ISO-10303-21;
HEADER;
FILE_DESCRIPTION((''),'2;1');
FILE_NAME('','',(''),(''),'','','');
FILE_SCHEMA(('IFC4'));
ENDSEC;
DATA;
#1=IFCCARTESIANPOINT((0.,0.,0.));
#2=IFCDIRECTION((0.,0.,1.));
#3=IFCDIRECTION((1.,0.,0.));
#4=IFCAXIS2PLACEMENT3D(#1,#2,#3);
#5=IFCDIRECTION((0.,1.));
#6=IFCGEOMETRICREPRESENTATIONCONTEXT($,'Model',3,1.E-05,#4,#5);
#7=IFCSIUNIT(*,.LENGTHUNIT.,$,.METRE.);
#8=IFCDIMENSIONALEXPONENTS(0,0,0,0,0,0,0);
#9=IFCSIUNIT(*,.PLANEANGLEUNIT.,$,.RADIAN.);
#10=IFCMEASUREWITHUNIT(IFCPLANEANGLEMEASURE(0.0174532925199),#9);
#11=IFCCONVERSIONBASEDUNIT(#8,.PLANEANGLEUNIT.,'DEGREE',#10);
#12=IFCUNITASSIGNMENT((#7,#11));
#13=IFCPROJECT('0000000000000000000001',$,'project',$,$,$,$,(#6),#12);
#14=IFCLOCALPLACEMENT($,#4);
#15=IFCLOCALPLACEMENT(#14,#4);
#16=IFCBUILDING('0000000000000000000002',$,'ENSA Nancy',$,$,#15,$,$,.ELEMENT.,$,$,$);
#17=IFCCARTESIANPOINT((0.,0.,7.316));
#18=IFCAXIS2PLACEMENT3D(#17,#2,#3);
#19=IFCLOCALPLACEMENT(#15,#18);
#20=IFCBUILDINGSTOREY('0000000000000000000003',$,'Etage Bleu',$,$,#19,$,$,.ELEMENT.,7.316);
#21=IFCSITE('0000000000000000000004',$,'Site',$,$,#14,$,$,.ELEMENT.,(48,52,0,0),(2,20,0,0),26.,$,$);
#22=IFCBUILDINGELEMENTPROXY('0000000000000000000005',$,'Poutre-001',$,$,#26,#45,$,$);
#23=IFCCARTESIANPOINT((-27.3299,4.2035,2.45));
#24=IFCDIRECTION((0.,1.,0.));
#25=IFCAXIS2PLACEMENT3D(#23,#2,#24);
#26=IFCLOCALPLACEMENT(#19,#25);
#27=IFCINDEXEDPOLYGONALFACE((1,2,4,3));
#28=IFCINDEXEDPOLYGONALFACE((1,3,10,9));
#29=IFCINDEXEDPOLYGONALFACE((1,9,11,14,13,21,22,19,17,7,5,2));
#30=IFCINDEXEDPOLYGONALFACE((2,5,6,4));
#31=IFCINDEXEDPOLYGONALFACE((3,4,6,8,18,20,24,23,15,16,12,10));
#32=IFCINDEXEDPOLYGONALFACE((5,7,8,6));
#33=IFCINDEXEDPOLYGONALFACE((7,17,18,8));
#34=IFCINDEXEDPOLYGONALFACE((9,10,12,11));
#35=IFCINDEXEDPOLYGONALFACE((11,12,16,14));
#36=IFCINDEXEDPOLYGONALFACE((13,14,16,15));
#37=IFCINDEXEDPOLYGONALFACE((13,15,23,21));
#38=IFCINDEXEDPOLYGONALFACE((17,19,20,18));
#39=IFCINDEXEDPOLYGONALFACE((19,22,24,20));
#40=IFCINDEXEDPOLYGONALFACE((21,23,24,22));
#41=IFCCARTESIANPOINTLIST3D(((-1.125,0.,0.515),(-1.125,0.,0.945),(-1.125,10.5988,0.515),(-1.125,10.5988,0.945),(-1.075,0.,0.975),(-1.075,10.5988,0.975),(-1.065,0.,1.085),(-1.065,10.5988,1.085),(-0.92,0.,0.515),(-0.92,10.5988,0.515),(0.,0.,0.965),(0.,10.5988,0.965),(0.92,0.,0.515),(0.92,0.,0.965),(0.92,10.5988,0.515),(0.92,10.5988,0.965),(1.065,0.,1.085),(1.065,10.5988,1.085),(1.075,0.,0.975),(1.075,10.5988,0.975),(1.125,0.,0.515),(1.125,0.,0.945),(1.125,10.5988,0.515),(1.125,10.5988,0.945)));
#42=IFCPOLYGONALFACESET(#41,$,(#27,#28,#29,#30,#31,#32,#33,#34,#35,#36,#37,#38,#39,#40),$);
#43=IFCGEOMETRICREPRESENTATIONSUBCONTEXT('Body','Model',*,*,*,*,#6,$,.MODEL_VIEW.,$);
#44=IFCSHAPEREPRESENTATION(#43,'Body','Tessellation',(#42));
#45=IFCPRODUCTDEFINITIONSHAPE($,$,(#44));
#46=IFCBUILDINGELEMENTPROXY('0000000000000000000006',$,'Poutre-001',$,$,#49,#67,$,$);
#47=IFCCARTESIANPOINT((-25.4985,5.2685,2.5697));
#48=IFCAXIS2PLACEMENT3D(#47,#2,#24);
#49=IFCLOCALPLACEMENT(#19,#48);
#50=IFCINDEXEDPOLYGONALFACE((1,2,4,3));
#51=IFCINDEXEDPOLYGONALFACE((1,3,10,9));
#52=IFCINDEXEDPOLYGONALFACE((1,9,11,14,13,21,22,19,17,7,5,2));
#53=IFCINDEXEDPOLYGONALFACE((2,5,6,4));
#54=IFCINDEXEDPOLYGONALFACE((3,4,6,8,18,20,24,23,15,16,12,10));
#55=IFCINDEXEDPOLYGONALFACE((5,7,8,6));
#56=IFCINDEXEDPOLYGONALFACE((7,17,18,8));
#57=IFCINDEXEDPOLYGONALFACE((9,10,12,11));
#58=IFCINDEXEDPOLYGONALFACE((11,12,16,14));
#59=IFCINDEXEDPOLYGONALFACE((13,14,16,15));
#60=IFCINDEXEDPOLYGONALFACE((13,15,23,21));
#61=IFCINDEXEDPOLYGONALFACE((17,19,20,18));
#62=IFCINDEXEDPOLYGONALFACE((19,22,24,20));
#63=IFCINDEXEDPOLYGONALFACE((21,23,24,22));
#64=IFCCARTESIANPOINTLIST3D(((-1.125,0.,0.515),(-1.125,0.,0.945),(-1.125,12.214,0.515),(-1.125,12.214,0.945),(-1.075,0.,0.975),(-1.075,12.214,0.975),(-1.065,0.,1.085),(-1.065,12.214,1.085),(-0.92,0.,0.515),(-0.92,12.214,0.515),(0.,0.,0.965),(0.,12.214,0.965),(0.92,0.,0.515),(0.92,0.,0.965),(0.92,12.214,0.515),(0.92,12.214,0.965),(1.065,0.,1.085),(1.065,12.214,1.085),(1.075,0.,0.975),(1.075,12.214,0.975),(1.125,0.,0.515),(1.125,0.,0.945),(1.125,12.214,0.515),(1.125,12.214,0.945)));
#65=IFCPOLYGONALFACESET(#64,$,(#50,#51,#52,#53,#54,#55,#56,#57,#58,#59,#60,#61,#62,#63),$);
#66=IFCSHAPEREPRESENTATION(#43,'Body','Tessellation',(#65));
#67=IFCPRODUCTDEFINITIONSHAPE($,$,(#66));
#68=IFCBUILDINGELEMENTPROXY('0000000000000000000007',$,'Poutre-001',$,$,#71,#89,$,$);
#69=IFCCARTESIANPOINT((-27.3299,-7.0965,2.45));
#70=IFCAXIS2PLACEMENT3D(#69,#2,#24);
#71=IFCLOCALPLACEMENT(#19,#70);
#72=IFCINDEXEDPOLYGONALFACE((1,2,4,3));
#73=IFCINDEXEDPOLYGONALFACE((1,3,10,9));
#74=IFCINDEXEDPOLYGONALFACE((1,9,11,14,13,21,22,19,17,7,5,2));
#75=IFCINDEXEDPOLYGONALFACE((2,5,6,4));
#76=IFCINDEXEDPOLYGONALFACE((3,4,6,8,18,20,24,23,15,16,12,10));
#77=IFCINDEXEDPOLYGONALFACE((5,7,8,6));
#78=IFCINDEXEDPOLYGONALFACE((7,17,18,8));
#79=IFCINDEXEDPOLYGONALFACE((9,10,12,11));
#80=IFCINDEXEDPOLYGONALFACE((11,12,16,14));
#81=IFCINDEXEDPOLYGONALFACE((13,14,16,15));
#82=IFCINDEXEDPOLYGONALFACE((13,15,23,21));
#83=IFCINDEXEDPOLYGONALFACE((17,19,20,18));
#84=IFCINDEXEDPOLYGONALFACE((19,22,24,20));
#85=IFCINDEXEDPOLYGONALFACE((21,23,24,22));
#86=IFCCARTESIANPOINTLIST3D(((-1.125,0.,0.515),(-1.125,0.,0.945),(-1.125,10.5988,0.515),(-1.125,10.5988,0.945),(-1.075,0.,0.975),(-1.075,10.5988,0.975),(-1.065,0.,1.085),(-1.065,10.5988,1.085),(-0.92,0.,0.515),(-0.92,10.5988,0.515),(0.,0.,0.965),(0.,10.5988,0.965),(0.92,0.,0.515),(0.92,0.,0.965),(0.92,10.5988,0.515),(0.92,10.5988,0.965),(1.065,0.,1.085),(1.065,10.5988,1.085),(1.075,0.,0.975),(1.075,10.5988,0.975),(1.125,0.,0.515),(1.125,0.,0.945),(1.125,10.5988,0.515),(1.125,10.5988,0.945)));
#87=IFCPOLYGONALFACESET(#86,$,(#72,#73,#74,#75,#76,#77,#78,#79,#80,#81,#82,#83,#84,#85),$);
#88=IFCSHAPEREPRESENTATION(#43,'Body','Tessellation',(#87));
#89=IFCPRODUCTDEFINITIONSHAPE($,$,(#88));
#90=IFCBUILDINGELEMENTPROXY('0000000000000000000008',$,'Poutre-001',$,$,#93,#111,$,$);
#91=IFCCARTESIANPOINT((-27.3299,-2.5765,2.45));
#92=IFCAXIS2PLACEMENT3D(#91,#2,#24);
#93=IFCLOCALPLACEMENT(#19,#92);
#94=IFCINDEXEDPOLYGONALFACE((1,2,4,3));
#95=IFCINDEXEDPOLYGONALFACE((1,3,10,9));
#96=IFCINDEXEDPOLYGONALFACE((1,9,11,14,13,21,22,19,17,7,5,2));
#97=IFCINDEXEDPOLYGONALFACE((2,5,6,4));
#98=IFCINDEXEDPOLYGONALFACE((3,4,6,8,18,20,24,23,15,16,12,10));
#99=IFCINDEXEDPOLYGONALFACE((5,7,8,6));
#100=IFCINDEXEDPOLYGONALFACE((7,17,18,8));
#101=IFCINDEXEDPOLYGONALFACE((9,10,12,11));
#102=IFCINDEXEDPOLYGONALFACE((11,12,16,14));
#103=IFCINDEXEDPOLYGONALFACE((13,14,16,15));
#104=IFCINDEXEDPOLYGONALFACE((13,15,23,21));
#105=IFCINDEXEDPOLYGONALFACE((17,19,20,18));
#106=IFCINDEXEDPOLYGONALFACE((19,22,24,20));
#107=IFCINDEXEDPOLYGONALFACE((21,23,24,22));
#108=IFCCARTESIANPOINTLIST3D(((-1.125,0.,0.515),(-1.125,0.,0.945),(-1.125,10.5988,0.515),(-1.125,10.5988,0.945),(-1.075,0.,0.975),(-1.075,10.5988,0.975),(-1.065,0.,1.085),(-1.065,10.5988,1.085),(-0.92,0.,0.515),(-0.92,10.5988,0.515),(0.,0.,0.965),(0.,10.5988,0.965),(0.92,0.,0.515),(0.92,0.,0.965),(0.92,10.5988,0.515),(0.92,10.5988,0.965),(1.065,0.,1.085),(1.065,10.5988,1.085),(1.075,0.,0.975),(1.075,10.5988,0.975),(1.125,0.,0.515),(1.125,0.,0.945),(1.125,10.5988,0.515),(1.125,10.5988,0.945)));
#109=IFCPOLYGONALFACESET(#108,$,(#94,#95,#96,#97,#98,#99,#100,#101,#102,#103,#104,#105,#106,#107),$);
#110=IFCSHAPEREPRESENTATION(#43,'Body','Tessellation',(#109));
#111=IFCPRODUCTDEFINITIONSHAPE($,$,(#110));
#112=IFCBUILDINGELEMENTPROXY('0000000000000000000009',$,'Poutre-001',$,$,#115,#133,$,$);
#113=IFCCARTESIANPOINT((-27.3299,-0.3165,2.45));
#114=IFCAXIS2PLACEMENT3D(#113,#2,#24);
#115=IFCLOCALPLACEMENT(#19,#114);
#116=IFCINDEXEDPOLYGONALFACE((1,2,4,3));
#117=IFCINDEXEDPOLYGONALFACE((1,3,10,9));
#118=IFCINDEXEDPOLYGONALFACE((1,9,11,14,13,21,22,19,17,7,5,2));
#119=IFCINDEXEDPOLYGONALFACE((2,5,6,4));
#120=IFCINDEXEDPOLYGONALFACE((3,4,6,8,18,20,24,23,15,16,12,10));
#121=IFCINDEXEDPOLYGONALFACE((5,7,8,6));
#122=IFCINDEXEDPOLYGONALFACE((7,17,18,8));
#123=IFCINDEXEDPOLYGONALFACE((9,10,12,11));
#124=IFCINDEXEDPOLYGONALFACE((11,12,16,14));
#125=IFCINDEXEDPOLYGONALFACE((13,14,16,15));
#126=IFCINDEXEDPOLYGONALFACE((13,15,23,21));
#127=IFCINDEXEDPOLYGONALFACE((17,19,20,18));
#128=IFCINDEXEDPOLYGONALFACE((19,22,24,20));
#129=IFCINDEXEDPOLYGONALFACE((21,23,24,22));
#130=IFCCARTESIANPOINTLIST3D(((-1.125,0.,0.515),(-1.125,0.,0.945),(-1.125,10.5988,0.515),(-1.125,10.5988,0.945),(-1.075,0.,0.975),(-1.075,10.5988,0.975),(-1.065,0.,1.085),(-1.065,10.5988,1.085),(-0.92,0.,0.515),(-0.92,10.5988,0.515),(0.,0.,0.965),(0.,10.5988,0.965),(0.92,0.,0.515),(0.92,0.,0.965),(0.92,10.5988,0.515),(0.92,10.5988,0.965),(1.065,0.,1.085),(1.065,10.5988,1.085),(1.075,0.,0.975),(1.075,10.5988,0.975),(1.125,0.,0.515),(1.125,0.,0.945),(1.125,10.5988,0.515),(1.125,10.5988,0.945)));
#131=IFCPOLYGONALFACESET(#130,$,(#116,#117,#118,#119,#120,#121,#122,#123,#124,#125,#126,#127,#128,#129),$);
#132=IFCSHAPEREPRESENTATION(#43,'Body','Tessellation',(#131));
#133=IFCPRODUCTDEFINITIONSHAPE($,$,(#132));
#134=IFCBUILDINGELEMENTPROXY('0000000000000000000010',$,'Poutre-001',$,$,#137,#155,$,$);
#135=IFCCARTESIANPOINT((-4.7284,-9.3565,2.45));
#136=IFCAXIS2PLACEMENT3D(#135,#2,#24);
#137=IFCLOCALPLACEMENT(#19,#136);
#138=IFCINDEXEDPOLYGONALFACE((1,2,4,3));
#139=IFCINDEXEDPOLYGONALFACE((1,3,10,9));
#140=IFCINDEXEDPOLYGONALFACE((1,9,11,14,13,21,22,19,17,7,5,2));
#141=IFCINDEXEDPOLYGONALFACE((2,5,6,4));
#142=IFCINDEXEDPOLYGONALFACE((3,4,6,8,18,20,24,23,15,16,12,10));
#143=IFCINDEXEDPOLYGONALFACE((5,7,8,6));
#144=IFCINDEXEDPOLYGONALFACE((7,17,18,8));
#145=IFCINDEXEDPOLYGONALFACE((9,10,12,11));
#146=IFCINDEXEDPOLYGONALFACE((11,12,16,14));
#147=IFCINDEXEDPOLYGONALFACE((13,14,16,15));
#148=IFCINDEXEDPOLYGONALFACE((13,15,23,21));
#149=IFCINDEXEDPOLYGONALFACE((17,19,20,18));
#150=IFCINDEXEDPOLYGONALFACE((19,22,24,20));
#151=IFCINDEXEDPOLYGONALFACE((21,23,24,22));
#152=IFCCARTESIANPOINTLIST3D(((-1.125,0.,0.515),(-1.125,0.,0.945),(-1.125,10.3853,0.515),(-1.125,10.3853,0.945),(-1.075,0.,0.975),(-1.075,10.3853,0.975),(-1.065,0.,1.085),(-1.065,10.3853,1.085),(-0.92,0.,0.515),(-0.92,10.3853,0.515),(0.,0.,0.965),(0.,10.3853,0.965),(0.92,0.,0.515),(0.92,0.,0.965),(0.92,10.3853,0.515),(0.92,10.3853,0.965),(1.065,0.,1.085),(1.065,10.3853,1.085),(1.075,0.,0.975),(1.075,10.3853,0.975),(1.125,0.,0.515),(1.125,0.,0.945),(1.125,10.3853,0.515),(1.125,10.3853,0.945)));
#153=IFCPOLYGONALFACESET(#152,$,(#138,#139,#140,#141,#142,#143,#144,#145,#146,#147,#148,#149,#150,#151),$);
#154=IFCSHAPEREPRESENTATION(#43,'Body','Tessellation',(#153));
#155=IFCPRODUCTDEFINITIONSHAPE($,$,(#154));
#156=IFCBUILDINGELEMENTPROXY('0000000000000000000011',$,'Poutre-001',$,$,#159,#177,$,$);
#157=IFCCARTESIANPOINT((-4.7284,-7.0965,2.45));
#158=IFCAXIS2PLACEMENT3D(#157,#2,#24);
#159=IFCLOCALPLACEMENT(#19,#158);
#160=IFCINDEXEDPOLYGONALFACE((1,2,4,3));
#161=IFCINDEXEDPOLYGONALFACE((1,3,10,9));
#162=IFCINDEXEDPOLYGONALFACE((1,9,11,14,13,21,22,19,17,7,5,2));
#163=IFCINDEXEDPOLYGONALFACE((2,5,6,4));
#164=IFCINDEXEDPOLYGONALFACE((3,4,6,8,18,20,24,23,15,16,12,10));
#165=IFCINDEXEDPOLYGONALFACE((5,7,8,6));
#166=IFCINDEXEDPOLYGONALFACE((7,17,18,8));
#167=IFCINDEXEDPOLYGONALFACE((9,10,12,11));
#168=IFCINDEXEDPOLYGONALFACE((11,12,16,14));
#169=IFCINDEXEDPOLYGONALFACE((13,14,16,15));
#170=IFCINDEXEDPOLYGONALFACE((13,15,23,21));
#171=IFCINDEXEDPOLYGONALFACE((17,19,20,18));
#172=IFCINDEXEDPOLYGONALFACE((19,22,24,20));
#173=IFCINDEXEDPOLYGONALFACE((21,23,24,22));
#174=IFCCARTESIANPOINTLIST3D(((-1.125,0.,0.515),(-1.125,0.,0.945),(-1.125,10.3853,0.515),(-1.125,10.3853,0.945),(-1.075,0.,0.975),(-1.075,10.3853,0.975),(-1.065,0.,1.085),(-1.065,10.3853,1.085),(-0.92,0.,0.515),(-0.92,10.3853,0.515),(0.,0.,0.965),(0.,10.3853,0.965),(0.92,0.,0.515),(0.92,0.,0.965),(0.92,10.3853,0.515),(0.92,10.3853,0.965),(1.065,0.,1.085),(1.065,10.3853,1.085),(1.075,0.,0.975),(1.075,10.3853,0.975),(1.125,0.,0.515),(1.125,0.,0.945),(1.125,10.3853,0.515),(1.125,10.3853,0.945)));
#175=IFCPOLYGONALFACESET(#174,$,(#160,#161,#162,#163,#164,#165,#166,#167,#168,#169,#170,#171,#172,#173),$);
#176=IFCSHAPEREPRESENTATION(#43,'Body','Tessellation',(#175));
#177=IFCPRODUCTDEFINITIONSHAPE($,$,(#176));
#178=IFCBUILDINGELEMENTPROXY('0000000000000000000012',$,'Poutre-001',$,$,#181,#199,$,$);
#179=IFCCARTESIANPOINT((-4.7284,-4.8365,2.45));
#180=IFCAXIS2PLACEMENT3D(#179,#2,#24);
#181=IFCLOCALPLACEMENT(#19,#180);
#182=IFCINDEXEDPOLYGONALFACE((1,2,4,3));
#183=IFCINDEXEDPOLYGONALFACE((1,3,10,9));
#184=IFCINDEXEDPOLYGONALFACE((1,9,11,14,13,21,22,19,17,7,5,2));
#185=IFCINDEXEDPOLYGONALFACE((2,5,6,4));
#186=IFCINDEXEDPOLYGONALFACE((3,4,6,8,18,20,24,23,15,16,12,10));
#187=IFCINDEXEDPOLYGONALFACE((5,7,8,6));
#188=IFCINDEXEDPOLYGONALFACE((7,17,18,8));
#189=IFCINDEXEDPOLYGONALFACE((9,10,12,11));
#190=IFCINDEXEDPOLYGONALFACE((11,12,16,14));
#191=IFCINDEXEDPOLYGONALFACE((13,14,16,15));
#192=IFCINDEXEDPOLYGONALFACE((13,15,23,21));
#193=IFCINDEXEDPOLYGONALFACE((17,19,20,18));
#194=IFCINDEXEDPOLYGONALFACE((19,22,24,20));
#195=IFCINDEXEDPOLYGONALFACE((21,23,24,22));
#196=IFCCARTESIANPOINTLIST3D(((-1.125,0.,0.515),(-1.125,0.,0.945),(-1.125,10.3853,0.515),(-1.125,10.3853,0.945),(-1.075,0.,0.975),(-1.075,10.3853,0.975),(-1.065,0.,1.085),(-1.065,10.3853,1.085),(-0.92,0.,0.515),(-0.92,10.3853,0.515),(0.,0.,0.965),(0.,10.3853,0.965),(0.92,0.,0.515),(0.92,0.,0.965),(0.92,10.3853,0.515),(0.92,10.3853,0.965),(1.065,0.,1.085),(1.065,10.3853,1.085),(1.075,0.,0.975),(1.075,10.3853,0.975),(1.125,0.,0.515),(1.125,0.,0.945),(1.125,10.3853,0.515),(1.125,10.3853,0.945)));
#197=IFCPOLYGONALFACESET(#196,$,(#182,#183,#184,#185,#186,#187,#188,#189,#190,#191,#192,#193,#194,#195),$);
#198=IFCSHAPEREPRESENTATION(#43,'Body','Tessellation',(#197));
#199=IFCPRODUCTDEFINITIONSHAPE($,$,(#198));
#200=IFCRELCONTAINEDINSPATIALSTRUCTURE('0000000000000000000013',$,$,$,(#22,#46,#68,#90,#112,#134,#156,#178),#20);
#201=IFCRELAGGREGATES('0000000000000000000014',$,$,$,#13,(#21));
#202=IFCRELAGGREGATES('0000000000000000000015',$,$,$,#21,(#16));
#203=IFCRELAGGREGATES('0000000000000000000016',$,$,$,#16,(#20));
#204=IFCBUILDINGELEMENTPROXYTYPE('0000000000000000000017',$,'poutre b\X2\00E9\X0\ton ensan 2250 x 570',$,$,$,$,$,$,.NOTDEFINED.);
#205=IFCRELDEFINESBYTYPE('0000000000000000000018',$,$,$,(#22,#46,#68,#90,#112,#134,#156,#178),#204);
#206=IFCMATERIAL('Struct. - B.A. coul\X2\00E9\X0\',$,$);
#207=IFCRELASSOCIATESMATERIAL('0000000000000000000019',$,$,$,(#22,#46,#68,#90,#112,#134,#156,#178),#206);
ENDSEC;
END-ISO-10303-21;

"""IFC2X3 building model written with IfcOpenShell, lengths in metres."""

from ifc_helpers import new_model, entity, si_unit, converted_unit, direction, frame, origin_with_axes, place, context, subcontext, project, spatial, polyline, outline, extrude, material, type_object, element, save


model = new_model("IFC2X3")

# Units and contexts
model_context = context("Model", 3, precision=1e-05, world=origin_with_axes(), true_north=direction((0.0, 1.0)))
body_context = subcontext(model_context, "Body", "Model", "MODEL_VIEW")
ifc_project = project(units=[si_unit("LENGTHUNIT", "METRE"), converted_unit("PLANEANGLEUNIT", "DEGREE", entity("IfcPlaneAngleMeasure", 0.0174532925199), si_unit("PLANEANGLEUNIT", "RADIAN"), dimensions=[0, 0, 0, 0, 0, 0, 0])], contexts=[model_context])

# Site, building, storey
site_placement = place(None, origin_with_axes())
site = spatial("IfcSite", under=ifc_project, at=site_placement, Name="Site", CompositionType="ELEMENT", RefLatitude=(48, 52, 0, 0), RefLongitude=(2, 20, 0, 0), RefElevation=26.0)
building_placement = place(site_placement, origin_with_axes())
building = spatial("IfcBuilding", under=site, at=building_placement, Name="ENSA Nancy", CompositionType="ELEMENT")
storey_placement = place(building_placement, frame((0.0, 0.0, 7.316), z_axis=(0.0, 0.0, 1.0), x_axis=(1.0, 0.0, 0.0)))
storey = spatial("IfcBuildingStorey", under=building, at=storey_placement, Name="Etage Bleu", CompositionType="ELEMENT", Elevation=7.316)

# Building element proxies
ifc_material_1 = material(Name="Struct. - B.A. coulé")
building_element_proxy_type_1 = type_object("IfcBuildingElementProxyType", Name="poutre béton ensan 2250 x 570", PredefinedType="NOTDEFINED")
proxy_1_placement = place(storey_placement, frame((-27.3299, 4.2035, 2.45), z_axis=(0.0, 0.0, 1.0), x_axis=(0.0, 1.0, 0.0)))
element("IfcBuildingElementProxy", 1, at=proxy_1_placement, inside=storey, type_object=building_element_proxy_type_1, material=ifc_material_1, Name="Poutre-001", context=body_context, shape_type="SweptSolid", body=[
    extrude(outline(polyline([(-1.065, 1.085), (-1.075, 0.975), (-1.125, 0.945), (-1.125, 0.515), (-0.92, 0.515), (0.0, 0.965), (0.92, 0.965), (0.92, 0.515), (1.125, 0.515), (1.125, 0.945), (1.075, 0.975), (1.065, 1.085), (-1.065, 1.085)])), frame((0.0, 10.5988, 0.0), z_axis=(0.0, -1.0, 0.0), x_axis=(1.0, 0.0, 0.0)), (0.0, 0.0, 1.0), 10.5988),
])
proxy_2_placement = place(storey_placement, frame((-25.4985, 5.2685, 2.5697), z_axis=(0.0, 0.0, 1.0), x_axis=(0.0, 1.0, 0.0)))
element("IfcBuildingElementProxy", 2, at=proxy_2_placement, inside=storey, type_object=building_element_proxy_type_1, material=ifc_material_1, Name="Poutre-001", context=body_context, shape_type="SweptSolid", body=[
    extrude(outline(polyline([(-1.065, 1.085), (-1.075, 0.975), (-1.125, 0.945), (-1.125, 0.515), (-0.92, 0.515), (0.0, 0.965), (0.92, 0.965), (0.92, 0.515), (1.125, 0.515), (1.125, 0.945), (1.075, 0.975), (1.065, 1.085), (-1.065, 1.085)])), frame((0.0, 12.214, 0.0), z_axis=(0.0, -1.0, 0.0), x_axis=(1.0, 0.0, 0.0)), (0.0, 0.0, 1.0), 12.214),
])
for number, where, z_axis, x_axis, name in (
    (3, (-27.3299, -7.0965, 2.45), (0.0, 0.0, 1.0), (0.0, 1.0, 0.0), "Poutre-001"),
    (4, (-27.3299, -2.5765, 2.45), (0.0, 0.0, 1.0), (0.0, 1.0, 0.0), "Poutre-001"),
    (5, (-27.3299, -0.3165, 2.45), (0.0, 0.0, 1.0), (0.0, 1.0, 0.0), "Poutre-001"),
):
    element("IfcBuildingElementProxy", number, at=place(storey_placement, frame(where, z_axis=z_axis, x_axis=x_axis)), inside=storey, type_object=building_element_proxy_type_1, material=ifc_material_1, Name=name, context=body_context, shape_type="SweptSolid", body=[
        extrude(outline(polyline([(-1.065, 1.085), (-1.075, 0.975), (-1.125, 0.945), (-1.125, 0.515), (-0.92, 0.515), (0.0, 0.965), (0.92, 0.965), (0.92, 0.515), (1.125, 0.515), (1.125, 0.945), (1.075, 0.975), (1.065, 1.085), (-1.065, 1.085)])), frame((0.0, 10.5988, 0.0), z_axis=(0.0, -1.0, 0.0), x_axis=(1.0, 0.0, 0.0)), (0.0, 0.0, 1.0), 10.5988),
    ])
for number, where, z_axis, x_axis, name in (
    (6, (-4.7284, -9.3565, 2.45), (0.0, 0.0, 1.0), (0.0, 1.0, 0.0), "Poutre-001"),
    (7, (-4.7284, -7.0965, 2.45), (0.0, 0.0, 1.0), (0.0, 1.0, 0.0), "Poutre-001"),
    (8, (-4.7284, -4.8365, 2.45), (0.0, 0.0, 1.0), (0.0, 1.0, 0.0), "Poutre-001"),
):
    element("IfcBuildingElementProxy", number, at=place(storey_placement, frame(where, z_axis=z_axis, x_axis=x_axis)), inside=storey, type_object=building_element_proxy_type_1, material=ifc_material_1, Name=name, context=body_context, shape_type="SweptSolid", body=[
        extrude(outline(polyline([(-1.065, 1.085), (-1.075, 0.975), (-1.125, 0.945), (-1.125, 0.515), (-0.92, 0.515), (0.0, 0.965), (0.92, 0.965), (0.92, 0.515), (1.125, 0.515), (1.125, 0.945), (1.075, 0.975), (1.065, 1.085), (-1.065, 1.085)])), frame((0.0, 10.3853, 0.0), z_axis=(0.0, -1.0, 0.0), x_axis=(1.0, 0.0, 0.0)), (0.0, 0.0, 1.0), 10.3853),
    ])

save(model, "model.ifc")
